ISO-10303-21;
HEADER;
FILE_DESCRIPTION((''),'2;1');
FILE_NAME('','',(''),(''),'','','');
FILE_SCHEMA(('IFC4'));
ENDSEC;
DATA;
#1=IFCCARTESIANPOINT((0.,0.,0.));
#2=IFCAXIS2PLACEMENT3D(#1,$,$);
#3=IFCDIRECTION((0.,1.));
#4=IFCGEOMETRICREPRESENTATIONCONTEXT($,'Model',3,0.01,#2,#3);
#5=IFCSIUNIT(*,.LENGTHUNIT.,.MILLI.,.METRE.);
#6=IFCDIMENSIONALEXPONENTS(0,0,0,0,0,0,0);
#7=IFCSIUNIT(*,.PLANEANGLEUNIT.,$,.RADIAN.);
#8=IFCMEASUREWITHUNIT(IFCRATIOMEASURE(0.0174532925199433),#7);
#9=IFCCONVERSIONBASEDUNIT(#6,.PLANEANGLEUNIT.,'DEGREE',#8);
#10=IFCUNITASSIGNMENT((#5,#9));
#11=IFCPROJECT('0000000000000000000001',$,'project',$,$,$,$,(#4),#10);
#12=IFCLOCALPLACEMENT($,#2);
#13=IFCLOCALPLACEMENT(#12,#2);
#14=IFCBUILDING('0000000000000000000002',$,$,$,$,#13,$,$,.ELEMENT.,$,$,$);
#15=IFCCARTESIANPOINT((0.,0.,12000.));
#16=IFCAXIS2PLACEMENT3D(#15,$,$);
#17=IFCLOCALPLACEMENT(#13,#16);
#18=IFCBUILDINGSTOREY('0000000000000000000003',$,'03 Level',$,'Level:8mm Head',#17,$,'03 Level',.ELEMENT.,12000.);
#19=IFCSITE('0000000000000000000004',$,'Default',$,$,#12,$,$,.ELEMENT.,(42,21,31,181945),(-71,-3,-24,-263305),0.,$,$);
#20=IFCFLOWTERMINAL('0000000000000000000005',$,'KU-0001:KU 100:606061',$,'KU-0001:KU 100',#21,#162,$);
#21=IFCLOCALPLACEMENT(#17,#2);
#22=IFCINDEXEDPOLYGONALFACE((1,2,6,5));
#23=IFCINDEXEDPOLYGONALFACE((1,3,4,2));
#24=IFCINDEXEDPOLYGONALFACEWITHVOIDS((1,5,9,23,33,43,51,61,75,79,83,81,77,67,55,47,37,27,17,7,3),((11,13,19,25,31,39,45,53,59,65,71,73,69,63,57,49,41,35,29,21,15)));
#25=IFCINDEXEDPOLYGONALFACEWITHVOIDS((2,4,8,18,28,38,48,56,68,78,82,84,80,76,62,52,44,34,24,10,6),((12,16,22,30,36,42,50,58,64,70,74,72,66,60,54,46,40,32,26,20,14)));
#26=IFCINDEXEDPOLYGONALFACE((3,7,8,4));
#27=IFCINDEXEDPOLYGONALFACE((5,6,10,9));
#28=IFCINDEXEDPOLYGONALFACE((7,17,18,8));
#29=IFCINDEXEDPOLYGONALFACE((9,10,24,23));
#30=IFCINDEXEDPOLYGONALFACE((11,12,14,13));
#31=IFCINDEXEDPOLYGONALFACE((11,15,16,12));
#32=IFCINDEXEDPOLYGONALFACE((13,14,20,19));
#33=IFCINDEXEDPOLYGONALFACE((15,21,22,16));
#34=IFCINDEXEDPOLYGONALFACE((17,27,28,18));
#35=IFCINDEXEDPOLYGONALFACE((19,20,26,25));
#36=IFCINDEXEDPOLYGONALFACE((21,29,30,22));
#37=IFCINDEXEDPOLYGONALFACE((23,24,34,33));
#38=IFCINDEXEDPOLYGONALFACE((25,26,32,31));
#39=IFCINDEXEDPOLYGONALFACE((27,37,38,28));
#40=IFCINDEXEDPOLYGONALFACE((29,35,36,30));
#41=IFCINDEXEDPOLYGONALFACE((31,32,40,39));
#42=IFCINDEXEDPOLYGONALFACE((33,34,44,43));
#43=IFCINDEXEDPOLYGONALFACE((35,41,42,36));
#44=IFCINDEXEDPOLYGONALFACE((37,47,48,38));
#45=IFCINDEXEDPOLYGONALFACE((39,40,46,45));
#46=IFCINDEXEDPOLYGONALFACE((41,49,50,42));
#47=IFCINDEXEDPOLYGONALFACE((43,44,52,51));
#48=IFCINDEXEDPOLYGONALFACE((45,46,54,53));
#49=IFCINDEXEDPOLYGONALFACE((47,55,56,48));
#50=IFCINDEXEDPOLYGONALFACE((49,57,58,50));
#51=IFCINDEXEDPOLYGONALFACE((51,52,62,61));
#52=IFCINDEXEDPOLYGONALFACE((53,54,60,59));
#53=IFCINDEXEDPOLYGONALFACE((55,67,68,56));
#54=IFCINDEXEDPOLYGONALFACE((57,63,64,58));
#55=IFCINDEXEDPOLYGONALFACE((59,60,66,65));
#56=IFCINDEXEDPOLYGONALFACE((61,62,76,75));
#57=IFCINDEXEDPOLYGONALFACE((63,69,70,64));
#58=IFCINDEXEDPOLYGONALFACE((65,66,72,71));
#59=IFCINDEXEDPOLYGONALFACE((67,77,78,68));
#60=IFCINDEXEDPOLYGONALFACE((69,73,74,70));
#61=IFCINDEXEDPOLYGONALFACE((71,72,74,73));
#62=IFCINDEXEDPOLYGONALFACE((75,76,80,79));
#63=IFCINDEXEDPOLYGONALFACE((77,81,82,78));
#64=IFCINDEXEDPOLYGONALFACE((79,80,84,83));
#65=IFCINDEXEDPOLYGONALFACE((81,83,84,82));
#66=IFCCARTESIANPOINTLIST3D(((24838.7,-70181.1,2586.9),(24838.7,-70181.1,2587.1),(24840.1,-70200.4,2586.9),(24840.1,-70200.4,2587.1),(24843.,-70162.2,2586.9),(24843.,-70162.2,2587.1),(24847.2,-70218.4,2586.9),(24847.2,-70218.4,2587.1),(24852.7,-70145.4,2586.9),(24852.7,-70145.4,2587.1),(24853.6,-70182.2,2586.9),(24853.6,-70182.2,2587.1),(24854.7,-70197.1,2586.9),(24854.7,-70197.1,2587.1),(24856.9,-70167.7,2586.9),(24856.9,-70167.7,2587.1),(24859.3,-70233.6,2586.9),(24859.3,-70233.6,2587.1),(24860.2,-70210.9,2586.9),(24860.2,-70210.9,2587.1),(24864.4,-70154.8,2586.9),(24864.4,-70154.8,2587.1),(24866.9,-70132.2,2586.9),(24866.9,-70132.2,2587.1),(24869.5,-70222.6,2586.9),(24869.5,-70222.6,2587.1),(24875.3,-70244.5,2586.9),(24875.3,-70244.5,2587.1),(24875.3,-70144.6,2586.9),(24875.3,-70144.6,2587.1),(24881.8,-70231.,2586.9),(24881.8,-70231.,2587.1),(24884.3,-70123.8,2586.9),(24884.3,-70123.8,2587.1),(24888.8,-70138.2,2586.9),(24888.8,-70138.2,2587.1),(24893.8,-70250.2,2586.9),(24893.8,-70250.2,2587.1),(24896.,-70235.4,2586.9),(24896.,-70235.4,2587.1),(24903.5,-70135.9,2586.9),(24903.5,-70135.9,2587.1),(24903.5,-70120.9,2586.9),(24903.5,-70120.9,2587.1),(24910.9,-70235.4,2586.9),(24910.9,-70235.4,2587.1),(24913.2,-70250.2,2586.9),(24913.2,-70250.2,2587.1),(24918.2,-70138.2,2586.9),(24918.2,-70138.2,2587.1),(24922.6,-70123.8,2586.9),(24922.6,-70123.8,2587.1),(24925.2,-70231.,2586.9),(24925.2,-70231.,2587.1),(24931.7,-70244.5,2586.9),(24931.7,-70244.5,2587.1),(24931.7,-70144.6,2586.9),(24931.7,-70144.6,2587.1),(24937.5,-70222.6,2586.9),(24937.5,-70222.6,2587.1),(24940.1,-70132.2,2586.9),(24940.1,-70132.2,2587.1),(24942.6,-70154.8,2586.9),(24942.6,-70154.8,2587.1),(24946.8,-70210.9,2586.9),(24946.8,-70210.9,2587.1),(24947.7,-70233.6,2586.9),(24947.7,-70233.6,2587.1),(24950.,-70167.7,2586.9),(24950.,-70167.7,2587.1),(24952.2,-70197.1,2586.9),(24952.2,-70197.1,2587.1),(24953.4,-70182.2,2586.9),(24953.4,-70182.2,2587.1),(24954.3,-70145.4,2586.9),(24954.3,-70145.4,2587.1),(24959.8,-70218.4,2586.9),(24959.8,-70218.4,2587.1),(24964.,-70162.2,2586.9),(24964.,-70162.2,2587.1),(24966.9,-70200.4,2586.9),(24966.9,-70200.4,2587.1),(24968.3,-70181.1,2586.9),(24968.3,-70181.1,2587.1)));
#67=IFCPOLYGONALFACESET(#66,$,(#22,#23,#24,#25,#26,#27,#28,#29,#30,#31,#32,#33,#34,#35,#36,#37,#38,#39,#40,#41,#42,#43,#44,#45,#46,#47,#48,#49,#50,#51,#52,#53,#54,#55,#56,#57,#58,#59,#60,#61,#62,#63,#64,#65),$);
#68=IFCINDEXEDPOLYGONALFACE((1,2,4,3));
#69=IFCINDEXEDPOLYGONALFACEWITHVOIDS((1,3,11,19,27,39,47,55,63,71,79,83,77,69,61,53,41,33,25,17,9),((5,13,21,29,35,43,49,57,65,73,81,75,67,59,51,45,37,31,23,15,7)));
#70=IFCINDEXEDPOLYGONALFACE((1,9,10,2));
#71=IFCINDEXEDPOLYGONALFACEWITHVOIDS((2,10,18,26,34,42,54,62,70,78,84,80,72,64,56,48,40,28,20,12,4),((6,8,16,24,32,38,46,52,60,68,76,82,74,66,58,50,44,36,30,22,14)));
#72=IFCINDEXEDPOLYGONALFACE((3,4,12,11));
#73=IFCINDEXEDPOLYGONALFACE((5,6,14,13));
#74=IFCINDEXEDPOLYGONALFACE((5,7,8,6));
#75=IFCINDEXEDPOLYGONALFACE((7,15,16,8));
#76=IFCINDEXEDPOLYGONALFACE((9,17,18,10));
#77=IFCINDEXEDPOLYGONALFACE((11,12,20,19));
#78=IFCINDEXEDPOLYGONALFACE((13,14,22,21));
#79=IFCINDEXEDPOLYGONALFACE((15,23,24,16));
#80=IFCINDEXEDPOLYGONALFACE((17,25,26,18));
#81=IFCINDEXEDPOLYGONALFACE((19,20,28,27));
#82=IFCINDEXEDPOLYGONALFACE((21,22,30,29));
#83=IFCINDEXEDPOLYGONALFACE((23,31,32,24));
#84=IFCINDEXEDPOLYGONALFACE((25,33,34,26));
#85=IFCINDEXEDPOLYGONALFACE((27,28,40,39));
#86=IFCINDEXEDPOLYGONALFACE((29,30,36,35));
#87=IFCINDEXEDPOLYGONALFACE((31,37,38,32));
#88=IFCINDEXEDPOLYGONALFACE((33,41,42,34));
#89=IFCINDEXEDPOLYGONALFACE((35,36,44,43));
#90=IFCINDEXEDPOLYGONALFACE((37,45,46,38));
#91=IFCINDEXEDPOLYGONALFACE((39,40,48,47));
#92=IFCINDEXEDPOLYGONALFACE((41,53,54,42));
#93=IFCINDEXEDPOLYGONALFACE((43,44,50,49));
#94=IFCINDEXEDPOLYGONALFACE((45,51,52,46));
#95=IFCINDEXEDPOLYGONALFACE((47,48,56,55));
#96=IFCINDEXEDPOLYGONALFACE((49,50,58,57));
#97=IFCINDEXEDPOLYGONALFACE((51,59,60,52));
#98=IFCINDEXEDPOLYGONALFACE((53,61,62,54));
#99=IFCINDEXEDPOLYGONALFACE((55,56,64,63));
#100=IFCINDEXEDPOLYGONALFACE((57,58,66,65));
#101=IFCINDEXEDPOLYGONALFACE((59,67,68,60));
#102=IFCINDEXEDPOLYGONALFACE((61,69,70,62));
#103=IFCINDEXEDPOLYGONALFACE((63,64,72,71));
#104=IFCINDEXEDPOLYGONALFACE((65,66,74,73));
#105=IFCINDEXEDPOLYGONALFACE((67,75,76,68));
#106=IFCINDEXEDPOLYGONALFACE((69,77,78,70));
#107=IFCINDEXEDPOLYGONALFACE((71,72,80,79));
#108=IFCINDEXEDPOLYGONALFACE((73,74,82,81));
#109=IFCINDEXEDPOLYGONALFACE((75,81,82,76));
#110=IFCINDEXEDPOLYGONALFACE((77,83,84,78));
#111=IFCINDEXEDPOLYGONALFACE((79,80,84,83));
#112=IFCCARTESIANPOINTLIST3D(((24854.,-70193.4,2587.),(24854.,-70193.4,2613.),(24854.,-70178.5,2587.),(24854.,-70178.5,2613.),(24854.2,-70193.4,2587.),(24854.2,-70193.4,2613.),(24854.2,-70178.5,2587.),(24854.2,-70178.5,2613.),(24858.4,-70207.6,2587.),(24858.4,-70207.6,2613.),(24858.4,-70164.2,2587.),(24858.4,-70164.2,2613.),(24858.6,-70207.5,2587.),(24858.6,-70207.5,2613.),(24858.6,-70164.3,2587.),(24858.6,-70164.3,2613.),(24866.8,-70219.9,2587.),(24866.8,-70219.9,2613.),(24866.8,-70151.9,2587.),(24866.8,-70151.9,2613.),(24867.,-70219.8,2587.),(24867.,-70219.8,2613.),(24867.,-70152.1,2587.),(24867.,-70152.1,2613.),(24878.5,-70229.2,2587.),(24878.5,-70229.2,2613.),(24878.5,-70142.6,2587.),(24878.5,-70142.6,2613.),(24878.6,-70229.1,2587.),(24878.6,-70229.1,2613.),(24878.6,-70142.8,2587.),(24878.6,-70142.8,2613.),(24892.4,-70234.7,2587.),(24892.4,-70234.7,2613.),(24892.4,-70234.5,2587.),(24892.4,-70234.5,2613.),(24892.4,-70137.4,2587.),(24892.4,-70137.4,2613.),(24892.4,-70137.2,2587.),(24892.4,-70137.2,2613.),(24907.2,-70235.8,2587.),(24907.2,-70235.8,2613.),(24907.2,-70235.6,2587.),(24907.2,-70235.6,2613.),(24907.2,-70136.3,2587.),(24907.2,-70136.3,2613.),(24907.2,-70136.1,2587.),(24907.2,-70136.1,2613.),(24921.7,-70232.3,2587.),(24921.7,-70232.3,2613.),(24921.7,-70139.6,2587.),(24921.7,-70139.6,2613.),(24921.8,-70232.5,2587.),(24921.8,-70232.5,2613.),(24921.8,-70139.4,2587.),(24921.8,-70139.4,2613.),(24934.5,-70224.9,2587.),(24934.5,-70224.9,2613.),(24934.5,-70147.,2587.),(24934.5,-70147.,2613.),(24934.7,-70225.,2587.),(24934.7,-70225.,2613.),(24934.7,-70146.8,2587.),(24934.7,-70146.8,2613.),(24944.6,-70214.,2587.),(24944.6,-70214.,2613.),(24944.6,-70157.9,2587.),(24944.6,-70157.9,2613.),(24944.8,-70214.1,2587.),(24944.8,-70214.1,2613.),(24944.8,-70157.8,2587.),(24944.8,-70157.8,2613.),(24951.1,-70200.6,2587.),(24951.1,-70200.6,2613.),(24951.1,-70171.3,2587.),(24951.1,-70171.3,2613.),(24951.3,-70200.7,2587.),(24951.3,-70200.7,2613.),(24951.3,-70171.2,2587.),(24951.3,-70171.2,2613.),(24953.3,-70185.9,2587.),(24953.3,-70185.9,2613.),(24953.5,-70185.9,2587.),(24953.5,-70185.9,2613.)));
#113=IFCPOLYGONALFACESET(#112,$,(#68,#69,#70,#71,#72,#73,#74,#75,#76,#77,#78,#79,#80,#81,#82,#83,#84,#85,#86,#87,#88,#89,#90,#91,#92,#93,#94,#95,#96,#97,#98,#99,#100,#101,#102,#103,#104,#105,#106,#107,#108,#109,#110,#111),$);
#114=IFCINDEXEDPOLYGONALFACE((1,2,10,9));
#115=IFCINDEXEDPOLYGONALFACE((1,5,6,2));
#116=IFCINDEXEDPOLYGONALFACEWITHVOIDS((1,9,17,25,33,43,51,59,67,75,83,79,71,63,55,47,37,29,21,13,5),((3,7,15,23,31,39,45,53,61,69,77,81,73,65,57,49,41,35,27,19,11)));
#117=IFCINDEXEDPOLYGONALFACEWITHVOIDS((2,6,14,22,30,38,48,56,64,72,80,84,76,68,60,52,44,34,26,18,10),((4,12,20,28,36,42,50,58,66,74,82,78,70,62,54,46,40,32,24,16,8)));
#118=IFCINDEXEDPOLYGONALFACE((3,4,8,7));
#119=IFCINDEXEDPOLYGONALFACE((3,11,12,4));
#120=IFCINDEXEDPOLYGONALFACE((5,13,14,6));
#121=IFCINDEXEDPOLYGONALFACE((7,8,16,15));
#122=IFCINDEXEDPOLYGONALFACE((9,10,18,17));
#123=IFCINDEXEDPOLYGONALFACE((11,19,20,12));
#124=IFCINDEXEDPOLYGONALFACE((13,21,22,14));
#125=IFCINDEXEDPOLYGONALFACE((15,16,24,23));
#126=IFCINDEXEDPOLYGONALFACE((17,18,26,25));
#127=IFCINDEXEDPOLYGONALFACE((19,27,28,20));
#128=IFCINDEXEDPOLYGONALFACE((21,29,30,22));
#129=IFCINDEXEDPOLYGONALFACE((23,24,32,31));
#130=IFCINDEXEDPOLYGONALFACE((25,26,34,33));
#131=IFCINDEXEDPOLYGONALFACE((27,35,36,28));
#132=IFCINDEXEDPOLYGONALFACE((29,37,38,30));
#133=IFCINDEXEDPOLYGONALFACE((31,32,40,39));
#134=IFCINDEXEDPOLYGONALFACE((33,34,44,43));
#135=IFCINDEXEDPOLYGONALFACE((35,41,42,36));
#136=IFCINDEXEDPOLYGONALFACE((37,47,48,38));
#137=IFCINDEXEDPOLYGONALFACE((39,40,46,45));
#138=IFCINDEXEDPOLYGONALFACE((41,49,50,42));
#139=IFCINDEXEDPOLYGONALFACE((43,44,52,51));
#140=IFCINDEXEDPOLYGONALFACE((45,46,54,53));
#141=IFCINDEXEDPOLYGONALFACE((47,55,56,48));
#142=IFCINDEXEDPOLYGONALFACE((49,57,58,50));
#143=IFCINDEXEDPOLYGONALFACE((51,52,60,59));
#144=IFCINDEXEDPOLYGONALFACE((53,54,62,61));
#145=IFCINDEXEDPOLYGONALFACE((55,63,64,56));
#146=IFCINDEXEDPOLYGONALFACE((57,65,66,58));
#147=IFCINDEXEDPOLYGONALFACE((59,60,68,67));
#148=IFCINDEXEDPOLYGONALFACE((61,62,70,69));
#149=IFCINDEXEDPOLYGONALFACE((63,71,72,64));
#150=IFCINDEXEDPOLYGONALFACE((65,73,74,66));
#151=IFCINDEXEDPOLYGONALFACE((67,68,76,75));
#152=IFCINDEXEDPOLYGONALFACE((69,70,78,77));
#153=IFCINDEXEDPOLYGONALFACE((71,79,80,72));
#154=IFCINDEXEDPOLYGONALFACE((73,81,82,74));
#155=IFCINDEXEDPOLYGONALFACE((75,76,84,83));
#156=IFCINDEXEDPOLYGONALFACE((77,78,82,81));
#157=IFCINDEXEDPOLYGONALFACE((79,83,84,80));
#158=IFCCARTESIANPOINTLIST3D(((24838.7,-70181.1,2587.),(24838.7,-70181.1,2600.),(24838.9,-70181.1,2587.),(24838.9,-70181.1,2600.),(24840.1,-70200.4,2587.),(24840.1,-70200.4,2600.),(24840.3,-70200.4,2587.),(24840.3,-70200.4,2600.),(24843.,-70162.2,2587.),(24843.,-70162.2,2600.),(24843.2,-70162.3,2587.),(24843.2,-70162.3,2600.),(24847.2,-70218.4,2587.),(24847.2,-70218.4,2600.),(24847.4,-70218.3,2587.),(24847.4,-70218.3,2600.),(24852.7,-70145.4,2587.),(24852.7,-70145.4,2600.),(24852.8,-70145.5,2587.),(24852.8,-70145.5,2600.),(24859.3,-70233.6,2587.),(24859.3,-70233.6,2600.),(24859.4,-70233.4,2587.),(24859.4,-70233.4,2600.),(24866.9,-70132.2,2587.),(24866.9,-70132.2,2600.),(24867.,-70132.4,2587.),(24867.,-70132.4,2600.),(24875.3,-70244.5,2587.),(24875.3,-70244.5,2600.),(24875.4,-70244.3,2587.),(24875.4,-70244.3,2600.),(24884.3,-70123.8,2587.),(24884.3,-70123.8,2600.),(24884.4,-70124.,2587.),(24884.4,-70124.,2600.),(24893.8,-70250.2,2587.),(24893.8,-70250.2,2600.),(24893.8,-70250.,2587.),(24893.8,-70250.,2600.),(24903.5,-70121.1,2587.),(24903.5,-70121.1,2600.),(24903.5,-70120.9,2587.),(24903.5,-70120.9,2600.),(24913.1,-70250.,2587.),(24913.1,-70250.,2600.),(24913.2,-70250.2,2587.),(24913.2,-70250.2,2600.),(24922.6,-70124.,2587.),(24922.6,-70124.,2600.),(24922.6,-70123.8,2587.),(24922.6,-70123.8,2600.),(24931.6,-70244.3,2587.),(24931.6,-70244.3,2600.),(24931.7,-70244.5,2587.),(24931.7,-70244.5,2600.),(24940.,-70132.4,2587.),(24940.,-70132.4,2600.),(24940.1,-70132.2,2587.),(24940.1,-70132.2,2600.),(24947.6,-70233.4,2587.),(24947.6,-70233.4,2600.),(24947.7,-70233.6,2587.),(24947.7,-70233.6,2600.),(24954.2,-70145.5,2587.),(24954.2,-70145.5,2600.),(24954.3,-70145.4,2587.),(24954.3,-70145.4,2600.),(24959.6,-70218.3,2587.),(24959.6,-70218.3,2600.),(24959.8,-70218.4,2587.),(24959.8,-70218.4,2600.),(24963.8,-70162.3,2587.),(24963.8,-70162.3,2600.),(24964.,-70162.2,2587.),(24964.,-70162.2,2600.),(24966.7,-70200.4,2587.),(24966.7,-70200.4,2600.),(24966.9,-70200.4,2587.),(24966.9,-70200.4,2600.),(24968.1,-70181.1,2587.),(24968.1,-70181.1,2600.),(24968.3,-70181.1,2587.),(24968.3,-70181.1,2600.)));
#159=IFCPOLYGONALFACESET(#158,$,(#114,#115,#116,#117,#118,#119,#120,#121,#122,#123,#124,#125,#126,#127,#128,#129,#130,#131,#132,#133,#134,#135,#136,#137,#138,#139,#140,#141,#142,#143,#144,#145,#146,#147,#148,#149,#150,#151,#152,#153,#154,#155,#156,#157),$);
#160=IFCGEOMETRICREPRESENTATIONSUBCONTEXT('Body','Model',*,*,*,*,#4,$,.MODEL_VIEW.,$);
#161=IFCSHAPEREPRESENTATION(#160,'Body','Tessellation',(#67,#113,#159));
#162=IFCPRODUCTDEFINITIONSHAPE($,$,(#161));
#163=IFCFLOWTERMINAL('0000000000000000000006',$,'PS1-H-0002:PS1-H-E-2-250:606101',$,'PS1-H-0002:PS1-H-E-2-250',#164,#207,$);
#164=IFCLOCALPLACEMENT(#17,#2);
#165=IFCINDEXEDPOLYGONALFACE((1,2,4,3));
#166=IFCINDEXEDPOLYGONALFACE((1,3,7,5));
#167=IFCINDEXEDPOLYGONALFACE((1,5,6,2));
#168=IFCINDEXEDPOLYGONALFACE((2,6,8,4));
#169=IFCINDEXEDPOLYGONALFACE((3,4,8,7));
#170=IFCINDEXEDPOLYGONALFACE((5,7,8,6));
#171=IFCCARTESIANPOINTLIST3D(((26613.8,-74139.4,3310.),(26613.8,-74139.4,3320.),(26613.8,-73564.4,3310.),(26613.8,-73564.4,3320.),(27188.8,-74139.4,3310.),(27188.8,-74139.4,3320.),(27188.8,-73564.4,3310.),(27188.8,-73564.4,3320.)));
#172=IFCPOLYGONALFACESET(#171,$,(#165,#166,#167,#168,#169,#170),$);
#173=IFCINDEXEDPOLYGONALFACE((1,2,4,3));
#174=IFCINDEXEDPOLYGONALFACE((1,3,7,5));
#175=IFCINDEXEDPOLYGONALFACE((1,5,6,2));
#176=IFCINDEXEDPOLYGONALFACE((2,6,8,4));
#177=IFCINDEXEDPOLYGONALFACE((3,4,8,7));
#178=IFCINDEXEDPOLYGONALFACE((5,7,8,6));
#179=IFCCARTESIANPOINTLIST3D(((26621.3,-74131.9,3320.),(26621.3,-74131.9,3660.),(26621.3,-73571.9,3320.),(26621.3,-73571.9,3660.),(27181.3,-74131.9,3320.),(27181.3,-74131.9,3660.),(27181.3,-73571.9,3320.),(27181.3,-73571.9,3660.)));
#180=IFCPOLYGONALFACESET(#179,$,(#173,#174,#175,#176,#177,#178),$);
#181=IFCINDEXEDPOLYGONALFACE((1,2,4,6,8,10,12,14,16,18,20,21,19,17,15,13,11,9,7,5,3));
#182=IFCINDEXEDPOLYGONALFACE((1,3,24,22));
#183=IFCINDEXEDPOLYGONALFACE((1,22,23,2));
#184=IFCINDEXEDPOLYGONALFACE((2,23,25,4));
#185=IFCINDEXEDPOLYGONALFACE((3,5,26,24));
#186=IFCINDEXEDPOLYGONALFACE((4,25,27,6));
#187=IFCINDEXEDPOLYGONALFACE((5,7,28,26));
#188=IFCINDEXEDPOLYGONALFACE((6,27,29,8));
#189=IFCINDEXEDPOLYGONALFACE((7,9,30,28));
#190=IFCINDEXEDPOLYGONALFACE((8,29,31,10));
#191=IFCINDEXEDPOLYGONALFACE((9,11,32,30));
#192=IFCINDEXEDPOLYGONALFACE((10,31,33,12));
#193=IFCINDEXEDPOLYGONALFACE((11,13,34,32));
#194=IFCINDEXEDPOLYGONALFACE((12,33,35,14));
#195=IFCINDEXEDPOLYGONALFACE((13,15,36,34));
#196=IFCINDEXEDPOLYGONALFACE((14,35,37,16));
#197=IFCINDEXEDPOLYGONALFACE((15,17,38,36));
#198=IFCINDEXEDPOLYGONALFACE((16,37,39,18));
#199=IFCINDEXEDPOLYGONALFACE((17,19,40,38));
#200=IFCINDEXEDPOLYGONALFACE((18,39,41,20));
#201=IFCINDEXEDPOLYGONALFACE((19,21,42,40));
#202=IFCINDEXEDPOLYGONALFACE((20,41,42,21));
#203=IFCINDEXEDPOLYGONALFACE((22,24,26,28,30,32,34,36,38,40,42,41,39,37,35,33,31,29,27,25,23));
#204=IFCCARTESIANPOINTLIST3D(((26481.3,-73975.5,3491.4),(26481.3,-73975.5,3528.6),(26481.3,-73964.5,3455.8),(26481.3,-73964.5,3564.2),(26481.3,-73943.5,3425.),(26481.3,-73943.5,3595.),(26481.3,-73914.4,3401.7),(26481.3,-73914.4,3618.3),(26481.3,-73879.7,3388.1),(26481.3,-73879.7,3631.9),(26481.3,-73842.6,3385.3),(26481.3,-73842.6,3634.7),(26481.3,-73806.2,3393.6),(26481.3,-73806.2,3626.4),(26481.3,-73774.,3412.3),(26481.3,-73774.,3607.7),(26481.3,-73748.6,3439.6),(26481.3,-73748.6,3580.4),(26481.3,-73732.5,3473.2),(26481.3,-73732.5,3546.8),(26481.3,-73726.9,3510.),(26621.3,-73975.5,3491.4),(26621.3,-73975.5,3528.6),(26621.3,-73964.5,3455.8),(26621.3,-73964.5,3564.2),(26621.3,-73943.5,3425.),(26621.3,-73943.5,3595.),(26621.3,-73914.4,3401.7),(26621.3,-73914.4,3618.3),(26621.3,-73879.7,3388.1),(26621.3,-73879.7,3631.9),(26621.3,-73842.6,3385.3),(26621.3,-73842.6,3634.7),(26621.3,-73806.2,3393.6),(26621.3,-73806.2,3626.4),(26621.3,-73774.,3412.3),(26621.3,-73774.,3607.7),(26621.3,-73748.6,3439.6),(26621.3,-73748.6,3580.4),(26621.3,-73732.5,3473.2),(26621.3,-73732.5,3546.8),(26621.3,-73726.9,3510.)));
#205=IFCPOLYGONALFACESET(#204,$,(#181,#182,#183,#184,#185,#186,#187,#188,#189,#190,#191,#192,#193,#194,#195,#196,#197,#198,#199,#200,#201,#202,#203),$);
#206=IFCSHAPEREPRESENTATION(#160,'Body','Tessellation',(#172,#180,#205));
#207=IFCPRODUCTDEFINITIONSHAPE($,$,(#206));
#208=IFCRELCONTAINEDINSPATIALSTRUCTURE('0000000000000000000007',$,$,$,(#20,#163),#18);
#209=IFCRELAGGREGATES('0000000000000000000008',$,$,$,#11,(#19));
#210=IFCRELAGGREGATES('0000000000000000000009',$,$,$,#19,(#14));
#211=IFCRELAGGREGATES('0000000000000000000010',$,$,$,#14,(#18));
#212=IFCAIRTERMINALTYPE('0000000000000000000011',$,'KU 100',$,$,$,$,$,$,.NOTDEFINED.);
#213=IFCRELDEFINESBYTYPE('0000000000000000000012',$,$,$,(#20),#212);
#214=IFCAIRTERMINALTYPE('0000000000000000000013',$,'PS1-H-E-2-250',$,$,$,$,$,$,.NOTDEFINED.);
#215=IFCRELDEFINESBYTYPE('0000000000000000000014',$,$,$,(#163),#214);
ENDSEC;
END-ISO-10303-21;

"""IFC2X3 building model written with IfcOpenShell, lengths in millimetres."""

from ifc_helpers import new_model, entity, si_unit, converted_unit, direction, frame, frame_2d, origin, origin_2d_with_axis, place, context, subcontext, project, spatial, rectangle, circle, hollow_circle, extrude, source, transform, mapped, type_object, type_shapes, element, save


model = new_model("IFC2X3")

# Units and contexts
model_context = context("Model", 3, precision=0.01, world=origin(), true_north=direction((0.0, 1.0)))
body_context = subcontext(model_context, "Body", "Model", "MODEL_VIEW")
ifc_project = project(units=[si_unit("LENGTHUNIT", "METRE", prefix="MILLI"), converted_unit("PLANEANGLEUNIT", "DEGREE", entity("IfcRatioMeasure", 0.0174532925199433), si_unit("PLANEANGLEUNIT", "RADIAN"), dimensions=[0, 0, 0, 0, 0, 0, 0])], contexts=[model_context])

# Site, building, storey
site_placement = place(None, origin())
site = spatial("IfcSite", under=ifc_project, at=site_placement, Name="Default", CompositionType="ELEMENT", RefLatitude=(42, 21, 31, 181945), RefLongitude=(-71, -3, -24, -263305), RefElevation=0.0)
building_placement = place(site_placement, origin())
building = spatial("IfcBuilding", under=site, at=building_placement, CompositionType="ELEMENT")
storey_placement = place(building_placement, frame((0.0, 0.0, 12000.0)))
storey = spatial("IfcBuildingStorey", under=building, at=storey_placement, Name="03 Level", ObjectType="Level:8mm Head", LongName="03 Level", CompositionType="ELEMENT", Elevation=12000.0)

# Flow terminals
air_terminal_type_1 = type_object("IfcAirTerminalType", Name="KU 100", PredefinedType="NOTDEFINED")
shared_shape_1 = source(origin(), body_context, "Body", "SweptSolid", [
    extrude(hollow_circle(Radius=65.0, WallThickness=15.0, at=frame_2d((0.0, 0.0), x_axis=(1.0, 0.0))), frame((12.9, 0.0, 0.0), z_axis=(1.0, 0.0, 0.0), x_axis=(0.0, 1.0, 0.0)), (0.0, 0.0, 1.0), 0.2),
    extrude(hollow_circle(Radius=50.0, WallThickness=0.2, at=frame_2d((0.0, 0.0), x_axis=(1.0, 0.0))), frame((-13.0, 0.0, 0.0), z_axis=(1.0, 0.0, 0.0), x_axis=(0.0, 0.0, 1.0)), (0.0, 0.0, 1.0), 26.0),
    extrude(hollow_circle(Radius=65.0, WallThickness=0.2, at=frame_2d((0.0, 0.0), x_axis=(1.0, 0.0))), frame((0.0, 0.0, 0.0), z_axis=(1.0, 0.0, 0.0), x_axis=(0.0, 1.0, 0.0)), (0.0, 0.0, 1.0), 13.0),
])
type_shapes(air_terminal_type_1, [shared_shape_1])
flow_terminal_1_placement = place(storey_placement, frame((24903.5, -70185.9, 2600.0), z_axis=(1.0, 0.0, 0.0), x_axis=(0.0, 0.0, -1.0)))
element("IfcFlowTerminal", 1, at=flow_terminal_1_placement, inside=storey, type_object=air_terminal_type_1, Name="KU-0001:KU 100:606061", ObjectType="KU-0001:KU 100", context=body_context, shape_type="MappedRepresentation", body=[
    mapped(shared_shape_1, transform((0.0, 0.0, 0.0), scale=1.0)),
])
air_terminal_type_2 = type_object("IfcAirTerminalType", Name="PS1-H-E-2-250", PredefinedType="NOTDEFINED")
shared_shape_2 = source(origin(), body_context, "Body", "SweptSolid", [
    extrude(rectangle(XDim=575.0, YDim=575.0, at=origin_2d_with_axis()), frame((0.0, 0.0, -10.0), z_axis=(0.0, 0.0, 1.0), x_axis=(-1.0, 0.0, 0.0)), (0.0, 0.0, 1.0), 10.0),
    extrude(rectangle(XDim=560.0, YDim=560.0, at=origin_2d_with_axis()), frame((0.0, 0.0, 0.0), z_axis=(0.0, 0.0, 1.0), x_axis=(-1.0, 0.0, 0.0)), (0.0, 0.0, 1.0), 340.0),
    extrude(circle(Radius=125.0, at=frame_2d((0.0, 0.0), x_axis=(1.0, 0.0))), frame((-420.0, 0.0, 190.0), z_axis=(1.0, 0.0, 0.0), x_axis=(0.0, 1.0, 0.0)), (0.0, 0.0, 1.0), 140.0),
])
type_shapes(air_terminal_type_2, [shared_shape_2])
flow_terminal_2_placement = place(storey_placement, frame((26901.3, -73851.9, 3320.0)))
element("IfcFlowTerminal", 2, at=flow_terminal_2_placement, inside=storey, type_object=air_terminal_type_2, Name="PS1-H-0002:PS1-H-E-2-250:606101", ObjectType="PS1-H-0002:PS1-H-E-2-250", context=body_context, shape_type="MappedRepresentation", body=[
    mapped(shared_shape_2, transform((0.0, 0.0, 0.0), scale=1.0)),
])

save(model, "model.ifc")
